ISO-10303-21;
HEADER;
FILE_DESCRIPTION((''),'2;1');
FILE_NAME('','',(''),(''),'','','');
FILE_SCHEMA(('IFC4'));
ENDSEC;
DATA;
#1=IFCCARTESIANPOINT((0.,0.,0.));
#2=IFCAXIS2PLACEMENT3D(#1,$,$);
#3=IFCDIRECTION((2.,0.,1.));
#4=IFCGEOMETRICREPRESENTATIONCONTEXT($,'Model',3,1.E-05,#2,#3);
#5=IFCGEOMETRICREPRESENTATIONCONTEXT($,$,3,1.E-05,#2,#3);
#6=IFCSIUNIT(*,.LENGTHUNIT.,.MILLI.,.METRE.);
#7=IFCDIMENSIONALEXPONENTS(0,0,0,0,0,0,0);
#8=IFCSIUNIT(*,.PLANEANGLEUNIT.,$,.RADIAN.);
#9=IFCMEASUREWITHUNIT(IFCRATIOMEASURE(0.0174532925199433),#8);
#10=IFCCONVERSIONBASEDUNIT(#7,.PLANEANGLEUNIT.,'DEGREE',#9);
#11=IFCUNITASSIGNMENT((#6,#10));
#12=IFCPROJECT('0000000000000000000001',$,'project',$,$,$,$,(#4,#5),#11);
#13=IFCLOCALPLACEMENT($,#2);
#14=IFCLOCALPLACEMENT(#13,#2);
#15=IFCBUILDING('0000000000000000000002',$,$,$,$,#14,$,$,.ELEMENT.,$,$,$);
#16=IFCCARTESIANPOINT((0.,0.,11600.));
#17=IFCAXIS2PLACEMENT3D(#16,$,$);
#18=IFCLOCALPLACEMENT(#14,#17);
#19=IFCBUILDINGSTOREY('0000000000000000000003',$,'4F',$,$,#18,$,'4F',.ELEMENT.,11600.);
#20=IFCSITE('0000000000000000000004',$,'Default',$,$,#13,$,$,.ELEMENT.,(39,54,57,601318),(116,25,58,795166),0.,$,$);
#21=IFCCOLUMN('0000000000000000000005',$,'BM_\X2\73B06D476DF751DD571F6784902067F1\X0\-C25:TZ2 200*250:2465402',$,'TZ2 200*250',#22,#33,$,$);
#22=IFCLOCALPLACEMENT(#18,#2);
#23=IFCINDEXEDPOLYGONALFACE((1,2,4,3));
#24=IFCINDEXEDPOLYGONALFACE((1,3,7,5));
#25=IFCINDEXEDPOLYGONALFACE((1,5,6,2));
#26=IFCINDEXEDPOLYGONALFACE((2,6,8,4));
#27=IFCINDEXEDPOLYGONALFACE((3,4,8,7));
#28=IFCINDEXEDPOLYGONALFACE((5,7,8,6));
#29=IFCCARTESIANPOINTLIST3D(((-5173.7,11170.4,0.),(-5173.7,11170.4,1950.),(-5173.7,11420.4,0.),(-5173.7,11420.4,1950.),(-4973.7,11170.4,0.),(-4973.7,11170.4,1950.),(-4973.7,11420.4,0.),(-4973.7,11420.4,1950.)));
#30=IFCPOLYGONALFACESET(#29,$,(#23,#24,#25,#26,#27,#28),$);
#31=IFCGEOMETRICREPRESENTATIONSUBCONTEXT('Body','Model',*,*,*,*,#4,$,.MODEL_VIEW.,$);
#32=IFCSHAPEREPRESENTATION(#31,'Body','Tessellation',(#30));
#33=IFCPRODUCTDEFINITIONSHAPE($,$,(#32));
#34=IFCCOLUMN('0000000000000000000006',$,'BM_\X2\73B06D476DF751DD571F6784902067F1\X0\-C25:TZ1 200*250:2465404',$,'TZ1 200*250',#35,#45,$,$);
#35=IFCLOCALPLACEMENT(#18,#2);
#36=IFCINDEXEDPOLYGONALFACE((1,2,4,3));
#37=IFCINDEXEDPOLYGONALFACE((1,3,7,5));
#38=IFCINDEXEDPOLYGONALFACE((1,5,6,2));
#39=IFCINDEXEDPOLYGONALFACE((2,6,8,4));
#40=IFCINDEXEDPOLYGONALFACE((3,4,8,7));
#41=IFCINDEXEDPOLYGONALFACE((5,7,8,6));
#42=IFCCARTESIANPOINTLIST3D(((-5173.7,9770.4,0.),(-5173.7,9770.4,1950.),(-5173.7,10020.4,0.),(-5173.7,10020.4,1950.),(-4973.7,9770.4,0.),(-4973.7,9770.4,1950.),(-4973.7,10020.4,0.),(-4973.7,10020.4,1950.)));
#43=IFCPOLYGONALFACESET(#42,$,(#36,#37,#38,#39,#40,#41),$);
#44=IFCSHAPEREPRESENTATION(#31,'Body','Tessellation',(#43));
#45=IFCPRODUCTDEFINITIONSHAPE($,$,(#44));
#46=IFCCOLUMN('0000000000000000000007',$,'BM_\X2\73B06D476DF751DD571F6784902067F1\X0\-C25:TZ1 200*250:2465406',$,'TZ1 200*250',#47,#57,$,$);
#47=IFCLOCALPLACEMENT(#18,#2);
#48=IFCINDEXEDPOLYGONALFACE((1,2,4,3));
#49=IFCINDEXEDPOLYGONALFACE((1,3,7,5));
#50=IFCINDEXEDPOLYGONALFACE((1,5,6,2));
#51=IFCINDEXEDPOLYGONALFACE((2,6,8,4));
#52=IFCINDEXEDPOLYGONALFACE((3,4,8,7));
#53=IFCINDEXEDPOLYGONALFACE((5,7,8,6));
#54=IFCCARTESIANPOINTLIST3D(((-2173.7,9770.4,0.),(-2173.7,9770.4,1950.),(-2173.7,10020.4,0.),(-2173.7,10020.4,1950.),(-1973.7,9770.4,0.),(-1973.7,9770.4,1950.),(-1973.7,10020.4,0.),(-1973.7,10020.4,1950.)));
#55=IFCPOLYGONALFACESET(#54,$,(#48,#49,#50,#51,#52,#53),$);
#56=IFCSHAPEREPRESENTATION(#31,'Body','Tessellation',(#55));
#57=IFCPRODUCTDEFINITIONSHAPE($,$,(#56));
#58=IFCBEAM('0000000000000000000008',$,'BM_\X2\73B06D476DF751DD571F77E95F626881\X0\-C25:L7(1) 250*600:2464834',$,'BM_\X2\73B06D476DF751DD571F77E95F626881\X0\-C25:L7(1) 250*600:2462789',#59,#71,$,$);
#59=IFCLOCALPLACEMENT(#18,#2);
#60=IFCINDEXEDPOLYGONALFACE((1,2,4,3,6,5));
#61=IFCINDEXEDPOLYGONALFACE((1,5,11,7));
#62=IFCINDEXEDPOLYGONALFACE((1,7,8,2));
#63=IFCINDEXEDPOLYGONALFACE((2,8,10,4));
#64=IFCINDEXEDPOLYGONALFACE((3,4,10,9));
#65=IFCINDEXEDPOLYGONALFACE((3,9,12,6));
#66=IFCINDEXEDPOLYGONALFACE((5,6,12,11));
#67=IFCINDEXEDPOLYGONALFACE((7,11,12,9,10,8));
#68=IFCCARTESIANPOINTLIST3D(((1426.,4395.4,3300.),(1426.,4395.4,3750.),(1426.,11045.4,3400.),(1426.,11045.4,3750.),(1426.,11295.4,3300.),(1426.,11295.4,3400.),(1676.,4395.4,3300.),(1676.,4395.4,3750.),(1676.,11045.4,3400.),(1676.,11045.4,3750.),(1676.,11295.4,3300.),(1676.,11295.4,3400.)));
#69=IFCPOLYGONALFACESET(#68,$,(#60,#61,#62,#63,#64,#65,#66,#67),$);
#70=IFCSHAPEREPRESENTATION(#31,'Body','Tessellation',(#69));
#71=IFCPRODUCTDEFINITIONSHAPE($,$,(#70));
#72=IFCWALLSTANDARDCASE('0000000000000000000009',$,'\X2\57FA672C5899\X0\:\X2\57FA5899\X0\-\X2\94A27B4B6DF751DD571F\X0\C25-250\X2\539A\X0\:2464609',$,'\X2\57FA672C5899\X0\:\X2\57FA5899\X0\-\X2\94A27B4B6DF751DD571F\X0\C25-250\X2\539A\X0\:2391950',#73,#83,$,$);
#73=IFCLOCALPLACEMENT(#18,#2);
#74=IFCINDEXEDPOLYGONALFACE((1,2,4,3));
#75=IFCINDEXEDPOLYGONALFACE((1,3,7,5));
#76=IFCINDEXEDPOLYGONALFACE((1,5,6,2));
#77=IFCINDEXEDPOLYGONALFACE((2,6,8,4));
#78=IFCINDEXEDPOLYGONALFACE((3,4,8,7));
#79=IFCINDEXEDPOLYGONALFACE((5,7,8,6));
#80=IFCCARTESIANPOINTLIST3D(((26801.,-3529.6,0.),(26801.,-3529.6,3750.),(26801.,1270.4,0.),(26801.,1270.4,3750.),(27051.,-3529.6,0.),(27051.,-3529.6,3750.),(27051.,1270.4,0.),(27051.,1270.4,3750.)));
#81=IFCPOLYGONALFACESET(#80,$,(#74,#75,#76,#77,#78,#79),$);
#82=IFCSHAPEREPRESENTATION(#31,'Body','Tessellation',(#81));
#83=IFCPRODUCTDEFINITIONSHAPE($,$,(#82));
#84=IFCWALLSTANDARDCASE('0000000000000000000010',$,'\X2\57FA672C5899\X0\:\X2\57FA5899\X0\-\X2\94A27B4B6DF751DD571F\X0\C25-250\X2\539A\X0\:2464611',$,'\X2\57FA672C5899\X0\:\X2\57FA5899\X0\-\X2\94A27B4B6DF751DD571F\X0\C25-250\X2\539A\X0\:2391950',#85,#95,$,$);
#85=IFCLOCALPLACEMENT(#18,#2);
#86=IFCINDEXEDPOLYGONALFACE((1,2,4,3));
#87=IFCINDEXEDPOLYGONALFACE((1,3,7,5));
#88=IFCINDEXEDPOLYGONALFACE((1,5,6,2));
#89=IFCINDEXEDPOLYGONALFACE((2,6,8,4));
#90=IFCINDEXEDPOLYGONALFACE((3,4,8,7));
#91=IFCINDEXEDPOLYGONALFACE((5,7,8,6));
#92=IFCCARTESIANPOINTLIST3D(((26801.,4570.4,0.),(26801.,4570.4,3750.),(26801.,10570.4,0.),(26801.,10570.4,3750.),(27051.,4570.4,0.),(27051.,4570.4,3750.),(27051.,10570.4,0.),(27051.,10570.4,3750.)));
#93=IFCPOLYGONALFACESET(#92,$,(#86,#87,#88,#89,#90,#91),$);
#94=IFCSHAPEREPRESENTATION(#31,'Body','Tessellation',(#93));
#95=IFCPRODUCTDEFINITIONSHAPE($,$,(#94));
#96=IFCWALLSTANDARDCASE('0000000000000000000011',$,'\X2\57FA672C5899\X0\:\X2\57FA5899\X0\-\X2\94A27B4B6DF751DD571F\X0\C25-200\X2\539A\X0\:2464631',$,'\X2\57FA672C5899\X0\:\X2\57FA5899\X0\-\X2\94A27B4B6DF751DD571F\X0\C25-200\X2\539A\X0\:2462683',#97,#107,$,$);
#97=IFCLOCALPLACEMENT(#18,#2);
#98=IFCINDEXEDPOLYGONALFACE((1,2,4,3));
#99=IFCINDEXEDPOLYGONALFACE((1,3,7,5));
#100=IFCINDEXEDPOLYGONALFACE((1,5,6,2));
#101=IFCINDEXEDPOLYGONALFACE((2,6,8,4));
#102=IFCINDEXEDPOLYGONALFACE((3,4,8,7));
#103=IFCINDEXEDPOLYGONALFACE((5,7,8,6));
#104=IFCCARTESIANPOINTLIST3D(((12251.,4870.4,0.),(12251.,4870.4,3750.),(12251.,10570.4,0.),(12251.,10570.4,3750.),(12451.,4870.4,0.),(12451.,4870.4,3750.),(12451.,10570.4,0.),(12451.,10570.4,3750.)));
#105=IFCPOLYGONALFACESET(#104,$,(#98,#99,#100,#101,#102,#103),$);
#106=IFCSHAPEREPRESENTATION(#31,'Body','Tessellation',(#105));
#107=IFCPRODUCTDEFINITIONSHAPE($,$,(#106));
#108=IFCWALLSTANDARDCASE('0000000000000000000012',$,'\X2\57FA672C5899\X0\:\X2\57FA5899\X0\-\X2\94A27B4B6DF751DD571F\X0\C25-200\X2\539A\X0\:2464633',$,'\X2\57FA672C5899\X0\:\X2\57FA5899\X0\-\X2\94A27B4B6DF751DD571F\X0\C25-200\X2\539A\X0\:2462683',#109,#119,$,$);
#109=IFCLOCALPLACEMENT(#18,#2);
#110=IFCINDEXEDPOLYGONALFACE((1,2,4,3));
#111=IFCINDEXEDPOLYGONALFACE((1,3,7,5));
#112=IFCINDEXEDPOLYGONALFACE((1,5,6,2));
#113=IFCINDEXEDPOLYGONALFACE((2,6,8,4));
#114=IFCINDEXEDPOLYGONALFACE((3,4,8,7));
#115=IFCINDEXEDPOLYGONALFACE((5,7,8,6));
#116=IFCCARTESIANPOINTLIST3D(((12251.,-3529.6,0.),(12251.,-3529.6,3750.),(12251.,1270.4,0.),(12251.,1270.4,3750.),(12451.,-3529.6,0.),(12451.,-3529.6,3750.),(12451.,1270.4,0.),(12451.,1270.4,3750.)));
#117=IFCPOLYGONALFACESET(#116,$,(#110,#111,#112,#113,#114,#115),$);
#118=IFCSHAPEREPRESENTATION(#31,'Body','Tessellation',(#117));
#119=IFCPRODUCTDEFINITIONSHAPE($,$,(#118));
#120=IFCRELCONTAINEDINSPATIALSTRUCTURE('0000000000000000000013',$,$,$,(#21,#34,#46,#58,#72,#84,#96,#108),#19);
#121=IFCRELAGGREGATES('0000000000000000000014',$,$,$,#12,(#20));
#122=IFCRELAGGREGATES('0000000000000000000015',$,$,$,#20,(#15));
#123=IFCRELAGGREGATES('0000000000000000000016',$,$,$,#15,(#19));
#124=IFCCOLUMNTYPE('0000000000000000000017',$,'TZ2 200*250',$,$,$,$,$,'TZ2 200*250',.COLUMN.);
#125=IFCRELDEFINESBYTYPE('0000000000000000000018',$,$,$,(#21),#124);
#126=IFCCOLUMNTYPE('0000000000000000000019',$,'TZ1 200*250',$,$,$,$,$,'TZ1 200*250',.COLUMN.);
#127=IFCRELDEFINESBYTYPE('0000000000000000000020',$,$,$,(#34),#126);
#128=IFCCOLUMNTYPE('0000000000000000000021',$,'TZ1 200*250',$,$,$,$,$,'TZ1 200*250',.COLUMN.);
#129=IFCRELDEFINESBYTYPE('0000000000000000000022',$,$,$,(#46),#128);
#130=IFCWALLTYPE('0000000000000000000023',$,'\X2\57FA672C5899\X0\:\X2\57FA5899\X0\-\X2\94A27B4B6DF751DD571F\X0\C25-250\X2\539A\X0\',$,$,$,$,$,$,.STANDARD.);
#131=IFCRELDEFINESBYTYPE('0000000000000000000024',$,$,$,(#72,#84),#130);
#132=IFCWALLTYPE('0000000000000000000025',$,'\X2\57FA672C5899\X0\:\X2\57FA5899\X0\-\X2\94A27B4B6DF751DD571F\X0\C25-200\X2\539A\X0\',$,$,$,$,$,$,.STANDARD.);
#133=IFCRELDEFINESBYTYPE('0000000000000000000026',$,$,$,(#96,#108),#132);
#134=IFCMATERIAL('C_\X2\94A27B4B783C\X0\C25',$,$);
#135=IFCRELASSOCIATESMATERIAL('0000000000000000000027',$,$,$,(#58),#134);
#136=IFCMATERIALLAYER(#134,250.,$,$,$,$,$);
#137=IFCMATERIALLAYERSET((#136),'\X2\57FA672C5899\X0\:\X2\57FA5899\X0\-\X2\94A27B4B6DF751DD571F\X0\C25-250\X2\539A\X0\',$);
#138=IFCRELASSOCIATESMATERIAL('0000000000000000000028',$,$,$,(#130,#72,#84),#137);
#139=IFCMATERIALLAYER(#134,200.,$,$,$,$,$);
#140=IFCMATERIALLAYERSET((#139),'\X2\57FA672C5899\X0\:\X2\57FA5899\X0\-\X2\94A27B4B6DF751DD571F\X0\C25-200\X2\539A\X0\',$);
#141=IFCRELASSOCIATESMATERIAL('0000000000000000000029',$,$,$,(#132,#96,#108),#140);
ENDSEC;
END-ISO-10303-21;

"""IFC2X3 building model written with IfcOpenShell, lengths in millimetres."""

from ifc_helpers import new_model, entity, si_unit, converted_unit, direction, frame, frame_2d, origin, place, context, subcontext, project, spatial, polyline, rectangle, extrude, clip, bounded_halfspace, source, transform, mapped, material, layer, layer_set, layer_usage, type_object, type_shapes, element, save


model = new_model("IFC2X3")

# Units and contexts
model_context = context("Model", 3, precision=1e-05, world=origin(), true_north=direction((2.0, 0.0, 1.0)))
context_of_model = context(None, 3, precision=1e-05, world=origin(), true_north=direction((2.0, 0.0, 1.0)))
body_context = subcontext(model_context, "Body", "Model", "MODEL_VIEW")
ifc_project = project(units=[si_unit("LENGTHUNIT", "METRE", prefix="MILLI"), converted_unit("PLANEANGLEUNIT", "DEGREE", entity("IfcRatioMeasure", 0.0174532925199433), si_unit("PLANEANGLEUNIT", "RADIAN"), dimensions=[0, 0, 0, 0, 0, 0, 0])], contexts=[model_context, context_of_model])

# Site, building, storey
site_placement = place(None, origin())
site = spatial("IfcSite", under=ifc_project, at=site_placement, Name="Default", CompositionType="ELEMENT", RefLatitude=(39, 54, 57, 601318), RefLongitude=(116, 25, 58, 795166), RefElevation=0.0)
building_placement = place(site_placement, origin())
building = spatial("IfcBuilding", under=site, at=building_placement, CompositionType="ELEMENT")
storey_placement = place(building_placement, frame((0.0, 0.0, 11600.0)))
storey = spatial("IfcBuildingStorey", under=building, at=storey_placement, Name="4F", LongName="4F", CompositionType="ELEMENT", Elevation=11600.0)

# Columns
column_type_1 = type_object("IfcColumnType", Name="TZ2 200*250", ElementType="TZ2 200*250", PredefinedType="COLUMN")
shared_shape_1 = source(origin(), body_context, "Body", "SweptSolid", [
    extrude(rectangle(XDim=250.0, YDim=200.0, at=frame_2d((-5073.7, 11295.4), x_axis=(0.0, -1.0))), origin(), (0.0, 0.0, 1.0), 1950.0),
])
type_shapes(column_type_1, [shared_shape_1])
column_1_placement = place(storey_placement, origin())
element("IfcColumn", 1, at=column_1_placement, inside=storey, type_object=column_type_1, Name="BM_现浇混凝土构造柱-C25:TZ2 200*250:2465402", ObjectType="TZ2 200*250", context=body_context, shape_type="MappedRepresentation", body=[
    mapped(shared_shape_1, transform((0.0, 0.0, 0.0), scale=1.0)),
])
column_type_2 = type_object("IfcColumnType", Name="TZ1 200*250", ElementType="TZ1 200*250", PredefinedType="COLUMN")
shared_shape_2 = source(origin(), body_context, "Body", "SweptSolid", [
    extrude(rectangle(XDim=250.0, YDim=200.0, at=frame_2d((-5073.7, 9895.4), x_axis=(0.0, -1.0))), origin(), (0.0, 0.0, 1.0), 1950.0),
])
type_shapes(column_type_2, [shared_shape_2])
column_2_placement = place(storey_placement, origin())
element("IfcColumn", 2, at=column_2_placement, inside=storey, type_object=column_type_2, Name="BM_现浇混凝土构造柱-C25:TZ1 200*250:2465404", ObjectType="TZ1 200*250", context=body_context, shape_type="MappedRepresentation", body=[
    mapped(shared_shape_2, transform((0.0, 0.0, 0.0), scale=1.0)),
])
column_type_3 = type_object("IfcColumnType", Name="TZ1 200*250", ElementType="TZ1 200*250", PredefinedType="COLUMN")
shared_shape_3 = source(origin(), body_context, "Body", "SweptSolid", [
    extrude(rectangle(XDim=250.0, YDim=200.0, at=frame_2d((-2073.7, 9895.4), x_axis=(0.0, -1.0))), origin(), (0.0, 0.0, 1.0), 1950.0),
])
type_shapes(column_type_3, [shared_shape_3])
column_3_placement = place(storey_placement, origin())
element("IfcColumn", 3, at=column_3_placement, inside=storey, type_object=column_type_3, Name="BM_现浇混凝土构造柱-C25:TZ1 200*250:2465406", ObjectType="TZ1 200*250", context=body_context, shape_type="MappedRepresentation", body=[
    mapped(shared_shape_3, transform((0.0, 0.0, 0.0), scale=1.0)),
])
ifc_material = material(Name="C_钢筋砼C25")

# Beam
beam_1_placement = place(storey_placement, frame((1551.0, 11170.4, 3900.0), z_axis=(0.0, 0.0, 1.0), x_axis=(0.0, -1.0, 0.0)))
element("IfcBeam", 4, at=beam_1_placement, inside=storey, material=ifc_material, Name="BM_现浇混凝土矩形梁-C25:L7(1) 250*600:2464834", ObjectType="BM_现浇混凝土矩形梁-C25:L7(1) 250*600:2462789", context=body_context, shape_type="Clipping", body=[
    clip(extrude(rectangle(XDim=450.0, YDim=250.0, at=frame_2d((0.0, 0.0), x_axis=(0.0, 1.0))), frame((-125.0, 0.0, -375.0), z_axis=(1.0, 0.0, 0.0), x_axis=(0.0, 1.0, 0.0)), (0.0, 0.0, 1.0), 6900.0), bounded_halfspace(frame((125.0, -10487.3, -500.0), z_axis=(-1.0, 0.0, 0.0), x_axis=(0.0, 0.0, 1.0)), False, frame((-125.0, 0.0, -375.0), z_axis=(1.0, 0.0, 0.0), x_axis=(0.0, 1.0, 0.0)), polyline([(125.0, -125.0), (-125.0, -125.0), (-125.0, 225.0), (125.0, 225.0), (125.0, -125.0)]))),
])

# Walls
ifc_layer_1 = layer(ifc_material, 250.0)
ifc_layer_set_1 = layer_set([ifc_layer_1], Name="基本墙:基墙-钢筋混凝土C25-250厚")
ifc_layer_usage_1 = layer_usage(ifc_layer_set_1, "AXIS2", "POSITIVE", -125.0)
wall_type_1 = type_object("IfcWallType", Name="基本墙:基墙-钢筋混凝土C25-250厚", PredefinedType="STANDARD", material=ifc_layer_set_1)
wall_1_placement = place(storey_placement, frame((26926.0, -3529.6, 0.0), z_axis=(0.0, 0.0, 1.0), x_axis=(0.0, 1.0, 0.0)))
element("IfcWallStandardCase", 5, at=wall_1_placement, inside=storey, type_object=wall_type_1, material=ifc_layer_usage_1, Name="基本墙:基墙-钢筋混凝土C25-250厚:2464609", ObjectType="基本墙:基墙-钢筋混凝土C25-250厚:2391950", context=body_context, shape_type="Clipping", body=[
    clip(clip(clip(extrude(rectangle(XDim=4800.0, YDim=250.0, at=frame_2d((2400.0, 0.0), x_axis=(-1.0, 0.0))), origin(), (0.0, 0.0, 1.0), 3900.0), bounded_halfspace(frame((4800.0, -125.0, 0.0), z_axis=(-1.0, 0.0, 0.0), x_axis=(0.0, 0.0, -1.0)), True, frame((4800.0, -125.0, 0.0), z_axis=(-1.0, 0.0, 0.0), x_axis=(0.0, 0.0, -1.0)), polyline([(0.0, 0.0), (-3750.0, 0.0), (-3750.0, -250.0), (0.0, -250.0), (0.0, 0.0)]))), bounded_halfspace(frame((0.0, 125.0, 0.0), z_axis=(1.0, 0.0, 0.0), x_axis=(0.0, 0.0, -1.0)), True, frame((0.0, 125.0, 0.0), z_axis=(1.0, 0.0, 0.0), x_axis=(0.0, 0.0, -1.0)), polyline([(0.0, 0.0), (-3750.0, 0.0), (-3750.0, -250.0), (0.0, -250.0), (0.0, 0.0)]))), bounded_halfspace(frame((0.0, -125.0, 3750.0), z_axis=(0.0, 0.0, -1.0), x_axis=(1.0, 0.0, 0.0)), True, frame((0.0, -125.0, 3750.0), z_axis=(0.0, 0.0, -1.0), x_axis=(1.0, 0.0, 0.0)), polyline([(0.0, 0.0), (0.0, -250.0), (4800.0, -250.0), (4800.0, 0.0), (0.0, 0.0)]))),
])
ifc_layer_usage_2 = layer_usage(ifc_layer_set_1, "AXIS2", "POSITIVE", -125.0)
wall_2_placement = place(storey_placement, frame((26926.0, 4570.4, 0.0), z_axis=(0.0, 0.0, 1.0), x_axis=(0.0, 1.0, 0.0)))
element("IfcWallStandardCase", 6, at=wall_2_placement, inside=storey, type_object=wall_type_1, material=ifc_layer_usage_2, Name="基本墙:基墙-钢筋混凝土C25-250厚:2464611", ObjectType="基本墙:基墙-钢筋混凝土C25-250厚:2391950", context=body_context, shape_type="Clipping", body=[
    clip(clip(clip(extrude(rectangle(XDim=6000.0, YDim=250.0, at=frame_2d((3000.0, 0.0), x_axis=(-1.0, 0.0))), origin(), (0.0, 0.0, 1.0), 3900.0), bounded_halfspace(frame((6000.0, -125.0, 0.0), z_axis=(1.0, 0.0, 0.0), x_axis=(0.0, 0.0, -1.0)), False, frame((6000.0, -125.0, 0.0), z_axis=(1.0, 0.0, 0.0), x_axis=(0.0, 0.0, -1.0)), polyline([(0.0, 0.0), (0.0, 250.0), (-3750.0, 250.0), (-3750.0, 0.0), (0.0, 0.0)]))), bounded_halfspace(frame((0.0, 125.0, 0.0), z_axis=(-1.0, 0.0, 0.0), x_axis=(0.0, 0.0, -1.0)), False, frame((0.0, 125.0, 0.0), z_axis=(-1.0, 0.0, 0.0), x_axis=(0.0, 0.0, -1.0)), polyline([(0.0, 0.0), (0.0, 250.0), (-3750.0, 250.0), (-3750.0, 0.0), (0.0, 0.0)]))), bounded_halfspace(frame((0.0, -125.0, 3750.0), z_axis=(0.0, 0.0, -1.0), x_axis=(1.0, 0.0, 0.0)), True, frame((0.0, -125.0, 3750.0), z_axis=(0.0, 0.0, -1.0), x_axis=(1.0, 0.0, 0.0)), polyline([(0.0, 0.0), (0.0, -250.0), (6000.0, -250.0), (6000.0, 0.0), (0.0, 0.0)]))),
])
ifc_layer_2 = layer(ifc_material, 200.0)
ifc_layer_set_2 = layer_set([ifc_layer_2], Name="基本墙:基墙-钢筋混凝土C25-200厚")
ifc_layer_usage_3 = layer_usage(ifc_layer_set_2, "AXIS2", "NEGATIVE", 100.0)
wall_type_2 = type_object("IfcWallType", Name="基本墙:基墙-钢筋混凝土C25-200厚", PredefinedType="STANDARD", material=ifc_layer_set_2)
wall_3_placement = place(storey_placement, frame((12351.0, 10570.4, 0.0), z_axis=(0.0, 0.0, 1.0), x_axis=(0.0, -1.0, 0.0)))
element("IfcWallStandardCase", 7, at=wall_3_placement, inside=storey, type_object=wall_type_2, material=ifc_layer_usage_3, Name="基本墙:基墙-钢筋混凝土C25-200厚:2464631", ObjectType="基本墙:基墙-钢筋混凝土C25-200厚:2462683", context=body_context, shape_type="Clipping", body=[
    clip(clip(clip(extrude(rectangle(XDim=5700.0, YDim=200.0, at=frame_2d((2850.0, 0.0), x_axis=(-1.0, 0.0))), origin(), (0.0, 0.0, 1.0), 3900.0), bounded_halfspace(frame((0.0, 100.0, 0.0), z_axis=(1.0, 0.0, 0.0), x_axis=(0.0, 0.0, -1.0)), True, frame((0.0, 100.0, 0.0), z_axis=(1.0, 0.0, 0.0), x_axis=(0.0, 0.0, -1.0)), polyline([(0.0, 0.0), (-3750.0, 0.0), (-3750.0, -200.0), (0.0, -200.0), (0.0, 0.0)]))), bounded_halfspace(frame((5700.0, -100.0, 0.0), z_axis=(-1.0, 0.0, 0.0), x_axis=(0.0, 0.0, -1.0)), True, frame((5700.0, -100.0, 0.0), z_axis=(-1.0, 0.0, 0.0), x_axis=(0.0, 0.0, -1.0)), polyline([(0.0, 0.0), (-3750.0, 0.0), (-3750.0, -200.0), (0.0, -200.0), (0.0, 0.0)]))), bounded_halfspace(frame((0.0, -100.0, 3750.0), z_axis=(0.0, 0.0, -1.0), x_axis=(-1.0, 0.0, 0.0)), True, frame((0.0, -100.0, 3750.0), z_axis=(0.0, 0.0, -1.0), x_axis=(-1.0, 0.0, 0.0)), polyline([(0.0, 0.0), (0.0, 200.0), (-5700.0, 200.0), (-5700.0, 0.0), (0.0, 0.0)]))),
])
ifc_layer_usage_4 = layer_usage(ifc_layer_set_2, "AXIS2", "NEGATIVE", 100.0)
wall_4_placement = place(storey_placement, frame((12351.0, 1270.4, 0.0), z_axis=(0.0, 0.0, 1.0), x_axis=(0.0, -1.0, 0.0)))
element("IfcWallStandardCase", 8, at=wall_4_placement, inside=storey, type_object=wall_type_2, material=ifc_layer_usage_4, Name="基本墙:基墙-钢筋混凝土C25-200厚:2464633", ObjectType="基本墙:基墙-钢筋混凝土C25-200厚:2462683", context=body_context, shape_type="Clipping", body=[
    clip(clip(clip(extrude(rectangle(XDim=4800.0, YDim=200.0, at=frame_2d((2400.0, 0.0), x_axis=(-1.0, 0.0))), origin(), (0.0, 0.0, 1.0), 3900.0), bounded_halfspace(frame((0.0, 100.0, 0.0), z_axis=(1.0, 0.0, 0.0), x_axis=(0.0, 0.0, -1.0)), True, frame((0.0, 100.0, 0.0), z_axis=(1.0, 0.0, 0.0), x_axis=(0.0, 0.0, -1.0)), polyline([(0.0, 0.0), (-3750.0, 0.0), (-3750.0, -200.0), (0.0, -200.0), (0.0, 0.0)]))), bounded_halfspace(frame((4800.0, -100.0, 0.0), z_axis=(-1.0, 0.0, 0.0), x_axis=(0.0, 0.0, -1.0)), True, frame((4800.0, -100.0, 0.0), z_axis=(-1.0, 0.0, 0.0), x_axis=(0.0, 0.0, -1.0)), polyline([(0.0, 0.0), (-3750.0, 0.0), (-3750.0, -200.0), (0.0, -200.0), (0.0, 0.0)]))), bounded_halfspace(frame((0.0, -100.0, 3750.0), z_axis=(0.0, 0.0, -1.0), x_axis=(-1.0, 0.0, 0.0)), True, frame((0.0, -100.0, 3750.0), z_axis=(0.0, 0.0, -1.0), x_axis=(-1.0, 0.0, 0.0)), polyline([(0.0, 0.0), (0.0, 200.0), (-4800.0, 200.0), (-4800.0, 0.0), (0.0, 0.0)]))),
])

save(model, "model.ifc")
